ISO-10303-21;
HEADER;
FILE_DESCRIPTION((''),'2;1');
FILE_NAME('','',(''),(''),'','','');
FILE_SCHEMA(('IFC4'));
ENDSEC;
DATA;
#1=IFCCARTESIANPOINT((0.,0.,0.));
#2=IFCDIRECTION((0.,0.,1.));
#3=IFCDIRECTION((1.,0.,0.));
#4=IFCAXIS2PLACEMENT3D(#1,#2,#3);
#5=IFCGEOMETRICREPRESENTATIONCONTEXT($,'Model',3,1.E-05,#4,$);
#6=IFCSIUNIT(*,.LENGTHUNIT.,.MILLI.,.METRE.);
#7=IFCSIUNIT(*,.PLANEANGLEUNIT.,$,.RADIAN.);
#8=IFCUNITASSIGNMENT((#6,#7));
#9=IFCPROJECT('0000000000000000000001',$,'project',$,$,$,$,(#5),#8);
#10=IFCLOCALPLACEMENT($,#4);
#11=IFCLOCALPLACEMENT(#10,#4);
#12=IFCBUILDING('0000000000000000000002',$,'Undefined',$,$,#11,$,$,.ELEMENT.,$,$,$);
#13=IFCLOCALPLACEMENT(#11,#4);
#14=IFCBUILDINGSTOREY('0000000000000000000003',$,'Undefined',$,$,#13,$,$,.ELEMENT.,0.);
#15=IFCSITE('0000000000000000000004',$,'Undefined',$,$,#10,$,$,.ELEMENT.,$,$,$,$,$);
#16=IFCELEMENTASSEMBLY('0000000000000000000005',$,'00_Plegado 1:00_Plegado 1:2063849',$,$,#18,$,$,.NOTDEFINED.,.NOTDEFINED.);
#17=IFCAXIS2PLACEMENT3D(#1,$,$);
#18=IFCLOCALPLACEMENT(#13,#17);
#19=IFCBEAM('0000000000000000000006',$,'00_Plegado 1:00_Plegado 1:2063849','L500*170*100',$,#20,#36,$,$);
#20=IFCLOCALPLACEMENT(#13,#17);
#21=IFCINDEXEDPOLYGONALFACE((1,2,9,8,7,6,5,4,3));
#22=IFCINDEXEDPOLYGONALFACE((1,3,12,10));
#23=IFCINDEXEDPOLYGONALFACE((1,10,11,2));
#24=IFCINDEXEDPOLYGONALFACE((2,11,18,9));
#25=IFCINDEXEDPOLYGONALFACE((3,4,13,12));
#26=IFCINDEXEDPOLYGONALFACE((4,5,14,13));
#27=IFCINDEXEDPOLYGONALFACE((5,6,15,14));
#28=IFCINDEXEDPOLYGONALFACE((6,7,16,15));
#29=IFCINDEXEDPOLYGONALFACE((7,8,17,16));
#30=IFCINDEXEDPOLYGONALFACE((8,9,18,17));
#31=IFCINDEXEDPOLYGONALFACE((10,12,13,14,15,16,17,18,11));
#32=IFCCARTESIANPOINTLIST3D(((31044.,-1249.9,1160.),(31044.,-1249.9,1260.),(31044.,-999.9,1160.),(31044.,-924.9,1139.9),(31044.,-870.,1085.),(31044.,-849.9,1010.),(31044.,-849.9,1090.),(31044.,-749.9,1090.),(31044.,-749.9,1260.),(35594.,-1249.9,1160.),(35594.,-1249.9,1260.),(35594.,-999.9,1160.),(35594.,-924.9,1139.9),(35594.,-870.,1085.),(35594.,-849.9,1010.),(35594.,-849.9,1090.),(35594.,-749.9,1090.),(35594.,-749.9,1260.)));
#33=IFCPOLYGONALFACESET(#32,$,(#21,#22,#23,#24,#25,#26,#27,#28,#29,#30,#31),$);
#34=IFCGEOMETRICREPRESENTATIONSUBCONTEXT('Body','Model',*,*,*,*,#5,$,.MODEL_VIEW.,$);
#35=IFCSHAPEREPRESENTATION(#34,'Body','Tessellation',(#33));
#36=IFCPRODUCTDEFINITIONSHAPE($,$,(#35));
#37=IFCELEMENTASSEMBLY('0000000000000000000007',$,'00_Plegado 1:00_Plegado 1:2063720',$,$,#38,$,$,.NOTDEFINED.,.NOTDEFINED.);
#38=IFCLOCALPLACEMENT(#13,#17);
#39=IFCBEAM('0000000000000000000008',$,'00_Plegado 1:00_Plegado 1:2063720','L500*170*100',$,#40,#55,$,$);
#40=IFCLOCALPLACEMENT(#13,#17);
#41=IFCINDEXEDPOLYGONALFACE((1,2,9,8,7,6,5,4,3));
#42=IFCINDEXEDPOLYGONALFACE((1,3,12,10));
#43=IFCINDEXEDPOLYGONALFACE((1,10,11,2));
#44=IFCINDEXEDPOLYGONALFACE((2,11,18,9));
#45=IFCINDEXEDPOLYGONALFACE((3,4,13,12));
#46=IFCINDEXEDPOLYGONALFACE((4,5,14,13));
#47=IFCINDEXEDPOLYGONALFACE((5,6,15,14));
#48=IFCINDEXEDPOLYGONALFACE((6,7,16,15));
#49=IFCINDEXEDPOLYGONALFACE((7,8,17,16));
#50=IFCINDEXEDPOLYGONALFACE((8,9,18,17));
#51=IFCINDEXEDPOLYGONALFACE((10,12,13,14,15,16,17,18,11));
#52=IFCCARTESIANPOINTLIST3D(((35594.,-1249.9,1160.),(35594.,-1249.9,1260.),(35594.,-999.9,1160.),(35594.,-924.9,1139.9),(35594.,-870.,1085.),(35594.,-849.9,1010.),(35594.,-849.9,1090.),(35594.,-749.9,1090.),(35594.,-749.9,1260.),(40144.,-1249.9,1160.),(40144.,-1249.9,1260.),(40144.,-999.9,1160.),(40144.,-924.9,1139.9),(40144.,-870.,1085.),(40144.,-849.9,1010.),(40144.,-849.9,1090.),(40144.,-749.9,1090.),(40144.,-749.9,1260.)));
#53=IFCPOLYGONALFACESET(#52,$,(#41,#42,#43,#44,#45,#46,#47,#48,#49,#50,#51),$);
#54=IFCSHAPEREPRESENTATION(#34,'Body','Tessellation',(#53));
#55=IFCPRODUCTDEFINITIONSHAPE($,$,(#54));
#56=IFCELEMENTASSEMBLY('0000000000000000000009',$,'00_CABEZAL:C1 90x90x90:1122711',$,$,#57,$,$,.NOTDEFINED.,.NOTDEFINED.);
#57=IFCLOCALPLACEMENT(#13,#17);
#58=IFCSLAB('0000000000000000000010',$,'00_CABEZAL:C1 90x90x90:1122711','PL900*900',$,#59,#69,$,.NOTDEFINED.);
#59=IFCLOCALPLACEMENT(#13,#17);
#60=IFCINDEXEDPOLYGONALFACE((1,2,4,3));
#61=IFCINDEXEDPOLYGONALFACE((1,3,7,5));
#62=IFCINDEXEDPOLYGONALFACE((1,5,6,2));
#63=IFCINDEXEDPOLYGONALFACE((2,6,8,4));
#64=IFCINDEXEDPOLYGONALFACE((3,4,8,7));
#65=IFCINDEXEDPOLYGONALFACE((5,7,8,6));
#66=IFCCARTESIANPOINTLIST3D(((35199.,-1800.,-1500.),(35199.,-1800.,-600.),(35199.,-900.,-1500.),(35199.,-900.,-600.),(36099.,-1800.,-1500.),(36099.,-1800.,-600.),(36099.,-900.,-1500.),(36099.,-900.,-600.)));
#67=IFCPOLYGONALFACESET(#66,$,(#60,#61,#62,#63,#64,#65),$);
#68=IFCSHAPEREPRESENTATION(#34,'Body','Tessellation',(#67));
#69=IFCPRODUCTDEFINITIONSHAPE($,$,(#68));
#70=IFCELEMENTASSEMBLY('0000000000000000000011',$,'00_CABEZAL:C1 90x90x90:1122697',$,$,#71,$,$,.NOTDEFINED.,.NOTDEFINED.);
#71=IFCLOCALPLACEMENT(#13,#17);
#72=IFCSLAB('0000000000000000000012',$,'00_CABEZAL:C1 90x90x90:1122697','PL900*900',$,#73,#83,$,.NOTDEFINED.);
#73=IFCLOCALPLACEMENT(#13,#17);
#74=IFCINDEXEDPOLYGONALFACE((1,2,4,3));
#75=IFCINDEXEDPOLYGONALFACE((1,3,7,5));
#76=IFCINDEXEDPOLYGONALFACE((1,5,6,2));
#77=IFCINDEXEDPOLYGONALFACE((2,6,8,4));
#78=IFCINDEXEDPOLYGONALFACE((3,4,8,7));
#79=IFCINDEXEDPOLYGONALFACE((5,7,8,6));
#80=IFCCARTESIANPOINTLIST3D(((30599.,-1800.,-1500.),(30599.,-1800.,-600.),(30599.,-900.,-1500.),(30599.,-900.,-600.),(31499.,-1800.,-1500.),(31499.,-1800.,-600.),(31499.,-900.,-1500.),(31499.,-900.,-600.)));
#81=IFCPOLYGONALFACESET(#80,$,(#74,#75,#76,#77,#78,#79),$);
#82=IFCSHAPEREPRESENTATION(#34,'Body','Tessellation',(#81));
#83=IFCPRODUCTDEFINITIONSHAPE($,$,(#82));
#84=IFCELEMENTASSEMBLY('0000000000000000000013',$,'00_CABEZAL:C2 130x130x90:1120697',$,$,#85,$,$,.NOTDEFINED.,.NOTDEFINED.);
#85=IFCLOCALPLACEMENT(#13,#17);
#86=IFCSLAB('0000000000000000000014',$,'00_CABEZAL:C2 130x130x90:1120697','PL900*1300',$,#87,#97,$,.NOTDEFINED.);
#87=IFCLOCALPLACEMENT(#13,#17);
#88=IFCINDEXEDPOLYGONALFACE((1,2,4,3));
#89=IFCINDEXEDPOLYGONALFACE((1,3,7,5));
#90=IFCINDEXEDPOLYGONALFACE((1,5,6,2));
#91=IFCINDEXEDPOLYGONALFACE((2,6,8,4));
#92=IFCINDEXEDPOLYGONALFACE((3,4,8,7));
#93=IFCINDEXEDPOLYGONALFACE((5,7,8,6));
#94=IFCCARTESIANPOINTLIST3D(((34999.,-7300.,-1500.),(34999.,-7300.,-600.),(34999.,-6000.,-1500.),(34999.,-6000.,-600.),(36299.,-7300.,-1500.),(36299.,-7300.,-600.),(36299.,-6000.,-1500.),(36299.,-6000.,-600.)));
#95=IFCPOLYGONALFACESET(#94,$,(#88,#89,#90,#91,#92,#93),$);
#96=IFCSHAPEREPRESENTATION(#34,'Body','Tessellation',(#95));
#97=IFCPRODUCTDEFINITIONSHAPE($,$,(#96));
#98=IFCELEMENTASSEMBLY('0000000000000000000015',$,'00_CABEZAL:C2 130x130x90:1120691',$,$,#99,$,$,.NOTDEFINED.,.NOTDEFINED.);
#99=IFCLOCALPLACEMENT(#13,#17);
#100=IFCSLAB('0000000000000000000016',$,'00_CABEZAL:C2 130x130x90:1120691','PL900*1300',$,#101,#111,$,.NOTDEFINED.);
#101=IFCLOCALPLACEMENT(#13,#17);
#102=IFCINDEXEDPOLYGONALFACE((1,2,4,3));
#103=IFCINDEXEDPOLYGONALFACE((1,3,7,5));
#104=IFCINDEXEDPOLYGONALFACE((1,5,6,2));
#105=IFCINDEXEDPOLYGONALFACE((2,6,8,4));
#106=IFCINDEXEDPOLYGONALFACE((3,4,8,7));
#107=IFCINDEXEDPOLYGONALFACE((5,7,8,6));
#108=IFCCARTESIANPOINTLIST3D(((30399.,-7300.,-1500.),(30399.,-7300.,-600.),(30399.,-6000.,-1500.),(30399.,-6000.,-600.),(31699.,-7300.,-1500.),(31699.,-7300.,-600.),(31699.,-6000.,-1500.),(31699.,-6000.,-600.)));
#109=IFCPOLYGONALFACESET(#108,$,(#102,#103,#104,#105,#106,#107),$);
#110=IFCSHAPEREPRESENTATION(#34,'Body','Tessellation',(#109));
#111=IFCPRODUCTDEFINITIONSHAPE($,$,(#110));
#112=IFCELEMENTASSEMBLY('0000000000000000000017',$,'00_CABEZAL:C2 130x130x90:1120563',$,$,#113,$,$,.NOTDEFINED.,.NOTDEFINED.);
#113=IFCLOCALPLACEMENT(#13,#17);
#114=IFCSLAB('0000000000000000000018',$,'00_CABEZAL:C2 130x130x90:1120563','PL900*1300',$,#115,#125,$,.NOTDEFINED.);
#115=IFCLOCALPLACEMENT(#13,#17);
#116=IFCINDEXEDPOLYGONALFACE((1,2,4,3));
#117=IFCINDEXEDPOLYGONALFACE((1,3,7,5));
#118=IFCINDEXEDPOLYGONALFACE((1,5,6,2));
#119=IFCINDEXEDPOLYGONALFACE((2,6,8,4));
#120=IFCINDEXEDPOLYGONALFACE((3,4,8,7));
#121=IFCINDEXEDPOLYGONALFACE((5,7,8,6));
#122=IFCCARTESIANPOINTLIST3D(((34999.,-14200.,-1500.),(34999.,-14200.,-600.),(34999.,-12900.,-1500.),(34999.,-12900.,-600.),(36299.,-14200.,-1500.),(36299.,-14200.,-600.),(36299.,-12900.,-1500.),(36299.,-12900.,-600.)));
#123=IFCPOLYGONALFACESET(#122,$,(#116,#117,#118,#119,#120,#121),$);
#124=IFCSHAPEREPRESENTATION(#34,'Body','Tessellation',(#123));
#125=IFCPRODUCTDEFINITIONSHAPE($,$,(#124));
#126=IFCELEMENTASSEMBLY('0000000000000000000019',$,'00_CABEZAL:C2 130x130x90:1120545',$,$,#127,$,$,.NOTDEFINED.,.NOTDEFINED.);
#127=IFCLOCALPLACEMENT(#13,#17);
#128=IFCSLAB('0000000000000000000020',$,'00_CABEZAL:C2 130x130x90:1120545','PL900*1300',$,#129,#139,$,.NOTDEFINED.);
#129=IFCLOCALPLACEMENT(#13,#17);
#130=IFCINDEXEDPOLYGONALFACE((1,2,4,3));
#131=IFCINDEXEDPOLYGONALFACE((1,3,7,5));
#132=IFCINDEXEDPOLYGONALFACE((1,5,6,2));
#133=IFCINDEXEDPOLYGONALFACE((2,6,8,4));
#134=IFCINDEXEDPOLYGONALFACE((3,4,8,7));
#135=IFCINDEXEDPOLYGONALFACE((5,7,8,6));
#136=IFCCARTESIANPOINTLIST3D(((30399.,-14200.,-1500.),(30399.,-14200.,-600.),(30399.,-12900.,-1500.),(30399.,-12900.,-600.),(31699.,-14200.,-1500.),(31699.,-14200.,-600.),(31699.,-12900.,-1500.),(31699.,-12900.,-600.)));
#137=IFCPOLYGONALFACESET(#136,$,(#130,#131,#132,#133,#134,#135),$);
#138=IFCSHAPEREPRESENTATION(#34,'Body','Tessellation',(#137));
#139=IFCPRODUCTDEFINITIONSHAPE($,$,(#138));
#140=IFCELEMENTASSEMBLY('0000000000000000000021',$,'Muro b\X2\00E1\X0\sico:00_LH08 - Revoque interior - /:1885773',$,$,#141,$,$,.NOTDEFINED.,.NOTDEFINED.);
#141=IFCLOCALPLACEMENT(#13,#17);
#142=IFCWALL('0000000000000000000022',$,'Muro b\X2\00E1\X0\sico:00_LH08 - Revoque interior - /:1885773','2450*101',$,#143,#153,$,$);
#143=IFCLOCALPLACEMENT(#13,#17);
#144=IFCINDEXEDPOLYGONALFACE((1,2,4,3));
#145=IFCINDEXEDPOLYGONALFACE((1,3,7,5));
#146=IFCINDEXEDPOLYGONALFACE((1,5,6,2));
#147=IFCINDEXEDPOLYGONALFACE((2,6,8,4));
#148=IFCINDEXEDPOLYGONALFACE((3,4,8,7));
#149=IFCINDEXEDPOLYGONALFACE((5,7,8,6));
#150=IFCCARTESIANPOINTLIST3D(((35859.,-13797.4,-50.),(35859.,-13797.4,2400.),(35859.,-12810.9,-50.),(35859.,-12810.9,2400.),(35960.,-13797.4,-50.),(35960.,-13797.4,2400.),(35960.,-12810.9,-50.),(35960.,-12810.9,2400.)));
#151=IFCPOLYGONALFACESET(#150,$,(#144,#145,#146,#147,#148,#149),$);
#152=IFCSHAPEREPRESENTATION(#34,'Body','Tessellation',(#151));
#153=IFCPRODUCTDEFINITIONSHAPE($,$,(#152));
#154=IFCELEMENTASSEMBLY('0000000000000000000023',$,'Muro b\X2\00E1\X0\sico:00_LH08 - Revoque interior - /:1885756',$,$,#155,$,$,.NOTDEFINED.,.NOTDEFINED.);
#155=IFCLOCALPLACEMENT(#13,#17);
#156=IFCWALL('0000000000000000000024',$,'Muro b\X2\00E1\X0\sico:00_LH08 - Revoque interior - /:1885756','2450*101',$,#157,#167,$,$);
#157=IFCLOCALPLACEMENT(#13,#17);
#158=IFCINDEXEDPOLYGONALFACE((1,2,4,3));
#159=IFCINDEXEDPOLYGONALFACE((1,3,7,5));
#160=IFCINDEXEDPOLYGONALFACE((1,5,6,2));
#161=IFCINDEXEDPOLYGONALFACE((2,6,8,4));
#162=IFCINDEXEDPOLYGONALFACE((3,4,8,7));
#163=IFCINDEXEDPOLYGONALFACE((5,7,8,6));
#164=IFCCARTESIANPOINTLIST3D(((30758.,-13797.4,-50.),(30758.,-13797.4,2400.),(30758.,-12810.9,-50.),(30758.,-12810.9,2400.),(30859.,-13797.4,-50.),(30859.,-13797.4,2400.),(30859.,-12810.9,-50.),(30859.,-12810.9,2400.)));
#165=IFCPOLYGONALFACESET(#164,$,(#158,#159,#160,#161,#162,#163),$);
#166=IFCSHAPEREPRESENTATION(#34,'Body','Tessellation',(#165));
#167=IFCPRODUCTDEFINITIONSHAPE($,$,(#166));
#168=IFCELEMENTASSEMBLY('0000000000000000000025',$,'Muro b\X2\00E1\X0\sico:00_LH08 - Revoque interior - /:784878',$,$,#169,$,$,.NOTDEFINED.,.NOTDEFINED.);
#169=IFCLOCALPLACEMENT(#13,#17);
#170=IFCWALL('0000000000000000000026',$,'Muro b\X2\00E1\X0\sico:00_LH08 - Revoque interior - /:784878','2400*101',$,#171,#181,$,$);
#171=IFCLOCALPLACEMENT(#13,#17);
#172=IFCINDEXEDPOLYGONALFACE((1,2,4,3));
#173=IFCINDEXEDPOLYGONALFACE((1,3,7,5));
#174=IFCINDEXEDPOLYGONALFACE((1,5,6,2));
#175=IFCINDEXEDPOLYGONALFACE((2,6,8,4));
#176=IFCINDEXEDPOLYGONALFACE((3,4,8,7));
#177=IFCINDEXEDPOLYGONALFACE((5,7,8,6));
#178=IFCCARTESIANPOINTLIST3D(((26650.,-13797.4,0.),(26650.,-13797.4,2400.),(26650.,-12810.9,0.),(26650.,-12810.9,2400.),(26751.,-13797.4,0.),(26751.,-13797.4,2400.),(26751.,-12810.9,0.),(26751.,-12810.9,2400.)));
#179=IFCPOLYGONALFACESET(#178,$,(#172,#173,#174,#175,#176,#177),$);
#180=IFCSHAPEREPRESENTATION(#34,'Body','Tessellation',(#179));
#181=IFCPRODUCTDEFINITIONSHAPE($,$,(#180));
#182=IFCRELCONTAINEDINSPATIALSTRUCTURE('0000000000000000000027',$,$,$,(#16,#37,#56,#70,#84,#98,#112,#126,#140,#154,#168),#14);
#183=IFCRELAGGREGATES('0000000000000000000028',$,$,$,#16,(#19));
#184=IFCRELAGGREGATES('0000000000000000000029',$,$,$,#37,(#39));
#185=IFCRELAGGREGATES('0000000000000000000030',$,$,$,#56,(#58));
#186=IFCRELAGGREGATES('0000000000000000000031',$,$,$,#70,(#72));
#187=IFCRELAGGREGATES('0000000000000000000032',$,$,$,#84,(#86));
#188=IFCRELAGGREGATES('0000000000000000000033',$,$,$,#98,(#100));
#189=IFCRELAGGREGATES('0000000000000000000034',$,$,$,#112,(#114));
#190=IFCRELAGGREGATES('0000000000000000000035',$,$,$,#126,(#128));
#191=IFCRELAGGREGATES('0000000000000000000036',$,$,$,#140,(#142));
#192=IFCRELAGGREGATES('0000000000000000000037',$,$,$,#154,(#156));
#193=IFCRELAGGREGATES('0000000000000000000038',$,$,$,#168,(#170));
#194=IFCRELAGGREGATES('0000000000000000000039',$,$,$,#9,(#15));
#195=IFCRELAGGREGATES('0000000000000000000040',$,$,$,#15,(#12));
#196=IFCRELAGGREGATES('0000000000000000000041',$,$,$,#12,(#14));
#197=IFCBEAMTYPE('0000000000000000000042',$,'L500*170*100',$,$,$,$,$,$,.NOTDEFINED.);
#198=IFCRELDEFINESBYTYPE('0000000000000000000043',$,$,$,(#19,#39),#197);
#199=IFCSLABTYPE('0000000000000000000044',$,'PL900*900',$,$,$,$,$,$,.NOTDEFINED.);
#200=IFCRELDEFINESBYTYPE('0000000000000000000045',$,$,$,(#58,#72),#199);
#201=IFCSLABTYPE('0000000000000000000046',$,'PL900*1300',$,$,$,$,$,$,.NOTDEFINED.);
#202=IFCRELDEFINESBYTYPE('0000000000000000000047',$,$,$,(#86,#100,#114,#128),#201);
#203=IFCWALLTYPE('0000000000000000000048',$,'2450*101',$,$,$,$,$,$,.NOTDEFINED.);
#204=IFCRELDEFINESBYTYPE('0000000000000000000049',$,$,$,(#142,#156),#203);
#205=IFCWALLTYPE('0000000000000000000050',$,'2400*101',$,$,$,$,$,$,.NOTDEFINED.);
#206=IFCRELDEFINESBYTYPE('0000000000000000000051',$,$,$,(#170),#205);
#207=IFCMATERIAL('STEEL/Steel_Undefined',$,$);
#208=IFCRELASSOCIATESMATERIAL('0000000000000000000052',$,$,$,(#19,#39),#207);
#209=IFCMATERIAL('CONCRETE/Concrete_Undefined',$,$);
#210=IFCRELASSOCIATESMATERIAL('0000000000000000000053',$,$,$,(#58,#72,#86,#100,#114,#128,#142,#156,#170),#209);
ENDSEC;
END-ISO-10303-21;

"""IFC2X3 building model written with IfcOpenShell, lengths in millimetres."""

from ifc_helpers import new_model, si_unit, frame, frame_2d, origin_with_axes, origin_2d_with_axis, place, context, subcontext, project, spatial, polyline, rectangle, l_section, outline, extrude, material, type_object, element, aggregate, save


model = new_model("IFC2X3")

# Units and contexts
model_context = context("Model", 3, precision=1e-05, world=origin_with_axes())
body_context = subcontext(model_context, "Body", "Model", "MODEL_VIEW")
ifc_project = project(units=[si_unit("LENGTHUNIT", "METRE", prefix="MILLI"), si_unit("PLANEANGLEUNIT", "RADIAN")], contexts=[model_context])

# Site, building, storey
site_placement = place(None, origin_with_axes())
site = spatial("IfcSite", under=ifc_project, at=site_placement, Name="Undefined", CompositionType="ELEMENT")
building_placement = place(site_placement, origin_with_axes())
building = spatial("IfcBuilding", under=site, at=building_placement, Name="Undefined", CompositionType="ELEMENT")
storey_placement = place(building_placement, origin_with_axes())
storey = spatial("IfcBuildingStorey", under=building, at=storey_placement, Name="Undefined", CompositionType="ELEMENT", Elevation=0.0)

# Shared definitions
ifc_material_1 = material(Name="STEEL/Steel_Undefined")

# Element assemblies, beams
assembly_1_placement = place(storey_placement, origin_with_axes())
assembly_1 = element("IfcElementAssembly", 1, at=assembly_1_placement, inside=storey, Name="00_Plegado 1:00_Plegado 1:2063849", AssemblyPlace="NOTDEFINED", PredefinedType="NOTDEFINED")
beam_type = type_object("IfcBeamType", Name="L500*170*100", PredefinedType="NOTDEFINED")
beam_1_placement = place(assembly_1_placement, frame((31044.0, -999.9, 1175.0), z_axis=(0.0, -1.0, 0.0), x_axis=(1.0, 0.0, 0.0)))
beam_1 = element("IfcBeam", 2, at=beam_1_placement, type_object=beam_type, material=ifc_material_1, Name="00_Plegado 1:00_Plegado 1:2063849", Description="L500*170*100", context=body_context, shape_type="SweptSolid", body=[
    extrude(l_section(Depth=500.0, Width=170.0, Thickness=100.0, FilletRadius=150.0, at=origin_2d_with_axis()), frame((4550.0, 0.0, 0.0), z_axis=(-1.0, 0.0, 0.0), x_axis=(0.0, -1.0, 0.0)), (0.0, 0.0, 1.0), 4550.0),
])
aggregate(assembly_1, [beam_1])
assembly_2_placement = place(storey_placement, origin_with_axes())
assembly_2 = element("IfcElementAssembly", 3, at=assembly_2_placement, inside=storey, Name="00_Plegado 1:00_Plegado 1:2063720", AssemblyPlace="NOTDEFINED", PredefinedType="NOTDEFINED")
beam_2_placement = place(assembly_2_placement, frame((35594.0, -999.9, 1175.0), z_axis=(0.0, -1.0, 0.0), x_axis=(1.0, 0.0, 0.0)))
beam_2 = element("IfcBeam", 4, at=beam_2_placement, type_object=beam_type, material=ifc_material_1, Name="00_Plegado 1:00_Plegado 1:2063720", Description="L500*170*100", context=body_context, shape_type="SweptSolid", body=[
    extrude(l_section(Depth=500.0, Width=170.0, Thickness=100.0, FilletRadius=150.0, at=origin_2d_with_axis()), frame((4550.0, 0.0, 0.0), z_axis=(-1.0, 0.0, 0.0), x_axis=(0.0, -1.0, 0.0)), (0.0, 0.0, 1.0), 4550.0),
])
aggregate(assembly_2, [beam_2])

# Element assemblies, slabs
assembly_3_placement = place(storey_placement, origin_with_axes())
assembly_3 = element("IfcElementAssembly", 5, at=assembly_3_placement, inside=storey, Name="00_CABEZAL:C1 90x90x90:1122711", AssemblyPlace="NOTDEFINED", PredefinedType="NOTDEFINED")
ifc_material_2 = material(Name="CONCRETE/Concrete_Undefined")
slab_type_1 = type_object("IfcSlabType", Name="PL900*900", PredefinedType="NOTDEFINED")
slab_1_placement = place(assembly_3_placement, frame((35199.0, -900.0, -1050.0), z_axis=(0.0, 0.0, -1.0), x_axis=(1.0, 0.0, 0.0)))
slab_1 = element("IfcSlab", 6, at=slab_1_placement, type_object=slab_type_1, material=ifc_material_2, Name="00_CABEZAL:C1 90x90x90:1122711", Description="PL900*900", PredefinedType="NOTDEFINED", context=body_context, shape_type="SweptSolid", body=[
    extrude(outline(polyline([(0.0, 0.0), (900.0, 0.0), (900.0, 900.0), (0.0, 900.0), (0.0, 0.0)])), frame((0.0, 0.0, -450.0), z_axis=(0.0, 0.0, 1.0), x_axis=(1.0, 0.0, 0.0)), (0.0, 0.0, 1.0), 900.0),
])
aggregate(assembly_3, [slab_1])
assembly_4_placement = place(storey_placement, origin_with_axes())
assembly_4 = element("IfcElementAssembly", 7, at=assembly_4_placement, inside=storey, Name="00_CABEZAL:C1 90x90x90:1122697", AssemblyPlace="NOTDEFINED", PredefinedType="NOTDEFINED")
slab_2_placement = place(assembly_4_placement, frame((30599.0, -900.0, -1050.0), z_axis=(0.0, 0.0, -1.0), x_axis=(1.0, 0.0, 0.0)))
slab_2 = element("IfcSlab", 8, at=slab_2_placement, type_object=slab_type_1, material=ifc_material_2, Name="00_CABEZAL:C1 90x90x90:1122697", Description="PL900*900", PredefinedType="NOTDEFINED", context=body_context, shape_type="SweptSolid", body=[
    extrude(outline(polyline([(0.0, 0.0), (900.0, 0.0), (900.0, 900.0), (0.0, 900.0), (0.0, 0.0)])), frame((0.0, 0.0, -450.0), z_axis=(0.0, 0.0, 1.0), x_axis=(1.0, 0.0, 0.0)), (0.0, 0.0, 1.0), 900.0),
])
aggregate(assembly_4, [slab_2])
assembly_5_placement = place(storey_placement, origin_with_axes())
assembly_5 = element("IfcElementAssembly", 9, at=assembly_5_placement, inside=storey, Name="00_CABEZAL:C2 130x130x90:1120697", AssemblyPlace="NOTDEFINED", PredefinedType="NOTDEFINED")
slab_type_2 = type_object("IfcSlabType", Name="PL900*1300", PredefinedType="NOTDEFINED")
slab_3_placement = place(assembly_5_placement, frame((34999.0, -6000.0, -1050.0), z_axis=(0.0, 0.0, -1.0), x_axis=(1.0, 0.0, 0.0)))
slab_3 = element("IfcSlab", 10, at=slab_3_placement, type_object=slab_type_2, material=ifc_material_2, Name="00_CABEZAL:C2 130x130x90:1120697", Description="PL900*1300", PredefinedType="NOTDEFINED", context=body_context, shape_type="SweptSolid", body=[
    extrude(outline(polyline([(0.0, 0.0), (1300.0, 0.0), (1300.0, 1300.0), (0.0, 1300.0), (0.0, 0.0)])), frame((0.0, 0.0, -450.0), z_axis=(0.0, 0.0, 1.0), x_axis=(1.0, 0.0, 0.0)), (0.0, 0.0, 1.0), 900.0),
])
aggregate(assembly_5, [slab_3])
assembly_6_placement = place(storey_placement, origin_with_axes())
assembly_6 = element("IfcElementAssembly", 11, at=assembly_6_placement, inside=storey, Name="00_CABEZAL:C2 130x130x90:1120691", AssemblyPlace="NOTDEFINED", PredefinedType="NOTDEFINED")
slab_4_placement = place(assembly_6_placement, frame((30399.0, -6000.0, -1050.0), z_axis=(0.0, 0.0, -1.0), x_axis=(1.0, 0.0, 0.0)))
slab_4 = element("IfcSlab", 12, at=slab_4_placement, type_object=slab_type_2, material=ifc_material_2, Name="00_CABEZAL:C2 130x130x90:1120691", Description="PL900*1300", PredefinedType="NOTDEFINED", context=body_context, shape_type="SweptSolid", body=[
    extrude(outline(polyline([(0.0, 0.0), (1300.0, 0.0), (1300.0, 1300.0), (0.0, 1300.0), (0.0, 0.0)])), frame((0.0, 0.0, -450.0), z_axis=(0.0, 0.0, 1.0), x_axis=(1.0, 0.0, 0.0)), (0.0, 0.0, 1.0), 900.0),
])
aggregate(assembly_6, [slab_4])
assembly_7_placement = place(storey_placement, origin_with_axes())
assembly_7 = element("IfcElementAssembly", 13, at=assembly_7_placement, inside=storey, Name="00_CABEZAL:C2 130x130x90:1120563", AssemblyPlace="NOTDEFINED", PredefinedType="NOTDEFINED")
slab_5_placement = place(assembly_7_placement, frame((34999.0, -12900.0, -1050.0), z_axis=(0.0, 0.0, -1.0), x_axis=(1.0, 0.0, 0.0)))
slab_5 = element("IfcSlab", 14, at=slab_5_placement, type_object=slab_type_2, material=ifc_material_2, Name="00_CABEZAL:C2 130x130x90:1120563", Description="PL900*1300", PredefinedType="NOTDEFINED", context=body_context, shape_type="SweptSolid", body=[
    extrude(outline(polyline([(0.0, 0.0), (1300.0, 0.0), (1300.0, 1300.0), (0.0, 1300.0), (0.0, 0.0)])), frame((0.0, 0.0, -450.0), z_axis=(0.0, 0.0, 1.0), x_axis=(1.0, 0.0, 0.0)), (0.0, 0.0, 1.0), 900.0),
])
aggregate(assembly_7, [slab_5])
assembly_8_placement = place(storey_placement, origin_with_axes())
assembly_8 = element("IfcElementAssembly", 15, at=assembly_8_placement, inside=storey, Name="00_CABEZAL:C2 130x130x90:1120545", AssemblyPlace="NOTDEFINED", PredefinedType="NOTDEFINED")
slab_6_placement = place(assembly_8_placement, frame((30399.0, -12900.0, -1050.0), z_axis=(0.0, 0.0, -1.0), x_axis=(1.0, 0.0, 0.0)))
slab_6 = element("IfcSlab", 16, at=slab_6_placement, type_object=slab_type_2, material=ifc_material_2, Name="00_CABEZAL:C2 130x130x90:1120545", Description="PL900*1300", PredefinedType="NOTDEFINED", context=body_context, shape_type="SweptSolid", body=[
    extrude(outline(polyline([(0.0, 0.0), (1300.0, 0.0), (1300.0, 1300.0), (0.0, 1300.0), (0.0, 0.0)])), frame((0.0, 0.0, -450.0), z_axis=(0.0, 0.0, 1.0), x_axis=(1.0, 0.0, 0.0)), (0.0, 0.0, 1.0), 900.0),
])
aggregate(assembly_8, [slab_6])

# Element assemblies, walls
assembly_9_placement = place(storey_placement, origin_with_axes())
assembly_9 = element("IfcElementAssembly", 17, at=assembly_9_placement, inside=storey, Name="Muro básico:00_LH08 - Revoque interior - /:1885773", AssemblyPlace="NOTDEFINED", PredefinedType="NOTDEFINED")
wall_type_1 = type_object("IfcWallType", Name="2450*101", PredefinedType="NOTDEFINED")
wall_1_placement = place(assembly_9_placement, frame((35909.5, -13797.4, -50.0), z_axis=(0.0, 0.0, 1.0), x_axis=(0.0, 1.0, 0.0)))
wall_1 = element("IfcWall", 18, at=wall_1_placement, type_object=wall_type_1, material=ifc_material_2, Name="Muro básico:00_LH08 - Revoque interior - /:1885773", Description="2450*101", context=body_context, shape_type="SweptSolid", body=[
    extrude(rectangle(XDim=986.5, YDim=101.0, at=frame_2d((0.0, 493.3), x_axis=(0.0, -1.0))), frame((0.0, 0.0, 0.0), z_axis=(0.0, 0.0, 1.0), x_axis=(0.0, -1.0, 0.0)), (0.0, 0.0, 1.0), 2450.0),
])
aggregate(assembly_9, [wall_1])
assembly_10_placement = place(storey_placement, origin_with_axes())
assembly_10 = element("IfcElementAssembly", 19, at=assembly_10_placement, inside=storey, Name="Muro básico:00_LH08 - Revoque interior - /:1885756", AssemblyPlace="NOTDEFINED", PredefinedType="NOTDEFINED")
wall_2_placement = place(assembly_10_placement, frame((30808.5, -13797.4, -50.0), z_axis=(0.0, 0.0, 1.0), x_axis=(0.0, 1.0, 0.0)))
wall_2 = element("IfcWall", 20, at=wall_2_placement, type_object=wall_type_1, material=ifc_material_2, Name="Muro básico:00_LH08 - Revoque interior - /:1885756", Description="2450*101", context=body_context, shape_type="SweptSolid", body=[
    extrude(rectangle(XDim=986.5, YDim=101.0, at=frame_2d((0.0, 493.3), x_axis=(0.0, -1.0))), frame((0.0, 0.0, 0.0), z_axis=(0.0, 0.0, 1.0), x_axis=(0.0, -1.0, 0.0)), (0.0, 0.0, 1.0), 2450.0),
])
aggregate(assembly_10, [wall_2])
assembly_11_placement = place(storey_placement, origin_with_axes())
assembly_11 = element("IfcElementAssembly", 21, at=assembly_11_placement, inside=storey, Name="Muro básico:00_LH08 - Revoque interior - /:784878", AssemblyPlace="NOTDEFINED", PredefinedType="NOTDEFINED")
wall_type_2 = type_object("IfcWallType", Name="2400*101", PredefinedType="NOTDEFINED")
wall_3_placement = place(assembly_11_placement, frame((26700.5, -13797.4, 0.0), z_axis=(0.0, 0.0, 1.0), x_axis=(0.0, 1.0, 0.0)))
wall_3 = element("IfcWall", 22, at=wall_3_placement, type_object=wall_type_2, material=ifc_material_2, Name="Muro básico:00_LH08 - Revoque interior - /:784878", Description="2400*101", context=body_context, shape_type="SweptSolid", body=[
    extrude(rectangle(XDim=986.5, YDim=101.0, at=frame_2d((0.0, 493.3), x_axis=(0.0, -1.0))), frame((0.0, 0.0, 0.0), z_axis=(0.0, 0.0, 1.0), x_axis=(0.0, -1.0, 0.0)), (0.0, 0.0, 1.0), 2400.0),
])
aggregate(assembly_11, [wall_3])

save(model, "model.ifc")
